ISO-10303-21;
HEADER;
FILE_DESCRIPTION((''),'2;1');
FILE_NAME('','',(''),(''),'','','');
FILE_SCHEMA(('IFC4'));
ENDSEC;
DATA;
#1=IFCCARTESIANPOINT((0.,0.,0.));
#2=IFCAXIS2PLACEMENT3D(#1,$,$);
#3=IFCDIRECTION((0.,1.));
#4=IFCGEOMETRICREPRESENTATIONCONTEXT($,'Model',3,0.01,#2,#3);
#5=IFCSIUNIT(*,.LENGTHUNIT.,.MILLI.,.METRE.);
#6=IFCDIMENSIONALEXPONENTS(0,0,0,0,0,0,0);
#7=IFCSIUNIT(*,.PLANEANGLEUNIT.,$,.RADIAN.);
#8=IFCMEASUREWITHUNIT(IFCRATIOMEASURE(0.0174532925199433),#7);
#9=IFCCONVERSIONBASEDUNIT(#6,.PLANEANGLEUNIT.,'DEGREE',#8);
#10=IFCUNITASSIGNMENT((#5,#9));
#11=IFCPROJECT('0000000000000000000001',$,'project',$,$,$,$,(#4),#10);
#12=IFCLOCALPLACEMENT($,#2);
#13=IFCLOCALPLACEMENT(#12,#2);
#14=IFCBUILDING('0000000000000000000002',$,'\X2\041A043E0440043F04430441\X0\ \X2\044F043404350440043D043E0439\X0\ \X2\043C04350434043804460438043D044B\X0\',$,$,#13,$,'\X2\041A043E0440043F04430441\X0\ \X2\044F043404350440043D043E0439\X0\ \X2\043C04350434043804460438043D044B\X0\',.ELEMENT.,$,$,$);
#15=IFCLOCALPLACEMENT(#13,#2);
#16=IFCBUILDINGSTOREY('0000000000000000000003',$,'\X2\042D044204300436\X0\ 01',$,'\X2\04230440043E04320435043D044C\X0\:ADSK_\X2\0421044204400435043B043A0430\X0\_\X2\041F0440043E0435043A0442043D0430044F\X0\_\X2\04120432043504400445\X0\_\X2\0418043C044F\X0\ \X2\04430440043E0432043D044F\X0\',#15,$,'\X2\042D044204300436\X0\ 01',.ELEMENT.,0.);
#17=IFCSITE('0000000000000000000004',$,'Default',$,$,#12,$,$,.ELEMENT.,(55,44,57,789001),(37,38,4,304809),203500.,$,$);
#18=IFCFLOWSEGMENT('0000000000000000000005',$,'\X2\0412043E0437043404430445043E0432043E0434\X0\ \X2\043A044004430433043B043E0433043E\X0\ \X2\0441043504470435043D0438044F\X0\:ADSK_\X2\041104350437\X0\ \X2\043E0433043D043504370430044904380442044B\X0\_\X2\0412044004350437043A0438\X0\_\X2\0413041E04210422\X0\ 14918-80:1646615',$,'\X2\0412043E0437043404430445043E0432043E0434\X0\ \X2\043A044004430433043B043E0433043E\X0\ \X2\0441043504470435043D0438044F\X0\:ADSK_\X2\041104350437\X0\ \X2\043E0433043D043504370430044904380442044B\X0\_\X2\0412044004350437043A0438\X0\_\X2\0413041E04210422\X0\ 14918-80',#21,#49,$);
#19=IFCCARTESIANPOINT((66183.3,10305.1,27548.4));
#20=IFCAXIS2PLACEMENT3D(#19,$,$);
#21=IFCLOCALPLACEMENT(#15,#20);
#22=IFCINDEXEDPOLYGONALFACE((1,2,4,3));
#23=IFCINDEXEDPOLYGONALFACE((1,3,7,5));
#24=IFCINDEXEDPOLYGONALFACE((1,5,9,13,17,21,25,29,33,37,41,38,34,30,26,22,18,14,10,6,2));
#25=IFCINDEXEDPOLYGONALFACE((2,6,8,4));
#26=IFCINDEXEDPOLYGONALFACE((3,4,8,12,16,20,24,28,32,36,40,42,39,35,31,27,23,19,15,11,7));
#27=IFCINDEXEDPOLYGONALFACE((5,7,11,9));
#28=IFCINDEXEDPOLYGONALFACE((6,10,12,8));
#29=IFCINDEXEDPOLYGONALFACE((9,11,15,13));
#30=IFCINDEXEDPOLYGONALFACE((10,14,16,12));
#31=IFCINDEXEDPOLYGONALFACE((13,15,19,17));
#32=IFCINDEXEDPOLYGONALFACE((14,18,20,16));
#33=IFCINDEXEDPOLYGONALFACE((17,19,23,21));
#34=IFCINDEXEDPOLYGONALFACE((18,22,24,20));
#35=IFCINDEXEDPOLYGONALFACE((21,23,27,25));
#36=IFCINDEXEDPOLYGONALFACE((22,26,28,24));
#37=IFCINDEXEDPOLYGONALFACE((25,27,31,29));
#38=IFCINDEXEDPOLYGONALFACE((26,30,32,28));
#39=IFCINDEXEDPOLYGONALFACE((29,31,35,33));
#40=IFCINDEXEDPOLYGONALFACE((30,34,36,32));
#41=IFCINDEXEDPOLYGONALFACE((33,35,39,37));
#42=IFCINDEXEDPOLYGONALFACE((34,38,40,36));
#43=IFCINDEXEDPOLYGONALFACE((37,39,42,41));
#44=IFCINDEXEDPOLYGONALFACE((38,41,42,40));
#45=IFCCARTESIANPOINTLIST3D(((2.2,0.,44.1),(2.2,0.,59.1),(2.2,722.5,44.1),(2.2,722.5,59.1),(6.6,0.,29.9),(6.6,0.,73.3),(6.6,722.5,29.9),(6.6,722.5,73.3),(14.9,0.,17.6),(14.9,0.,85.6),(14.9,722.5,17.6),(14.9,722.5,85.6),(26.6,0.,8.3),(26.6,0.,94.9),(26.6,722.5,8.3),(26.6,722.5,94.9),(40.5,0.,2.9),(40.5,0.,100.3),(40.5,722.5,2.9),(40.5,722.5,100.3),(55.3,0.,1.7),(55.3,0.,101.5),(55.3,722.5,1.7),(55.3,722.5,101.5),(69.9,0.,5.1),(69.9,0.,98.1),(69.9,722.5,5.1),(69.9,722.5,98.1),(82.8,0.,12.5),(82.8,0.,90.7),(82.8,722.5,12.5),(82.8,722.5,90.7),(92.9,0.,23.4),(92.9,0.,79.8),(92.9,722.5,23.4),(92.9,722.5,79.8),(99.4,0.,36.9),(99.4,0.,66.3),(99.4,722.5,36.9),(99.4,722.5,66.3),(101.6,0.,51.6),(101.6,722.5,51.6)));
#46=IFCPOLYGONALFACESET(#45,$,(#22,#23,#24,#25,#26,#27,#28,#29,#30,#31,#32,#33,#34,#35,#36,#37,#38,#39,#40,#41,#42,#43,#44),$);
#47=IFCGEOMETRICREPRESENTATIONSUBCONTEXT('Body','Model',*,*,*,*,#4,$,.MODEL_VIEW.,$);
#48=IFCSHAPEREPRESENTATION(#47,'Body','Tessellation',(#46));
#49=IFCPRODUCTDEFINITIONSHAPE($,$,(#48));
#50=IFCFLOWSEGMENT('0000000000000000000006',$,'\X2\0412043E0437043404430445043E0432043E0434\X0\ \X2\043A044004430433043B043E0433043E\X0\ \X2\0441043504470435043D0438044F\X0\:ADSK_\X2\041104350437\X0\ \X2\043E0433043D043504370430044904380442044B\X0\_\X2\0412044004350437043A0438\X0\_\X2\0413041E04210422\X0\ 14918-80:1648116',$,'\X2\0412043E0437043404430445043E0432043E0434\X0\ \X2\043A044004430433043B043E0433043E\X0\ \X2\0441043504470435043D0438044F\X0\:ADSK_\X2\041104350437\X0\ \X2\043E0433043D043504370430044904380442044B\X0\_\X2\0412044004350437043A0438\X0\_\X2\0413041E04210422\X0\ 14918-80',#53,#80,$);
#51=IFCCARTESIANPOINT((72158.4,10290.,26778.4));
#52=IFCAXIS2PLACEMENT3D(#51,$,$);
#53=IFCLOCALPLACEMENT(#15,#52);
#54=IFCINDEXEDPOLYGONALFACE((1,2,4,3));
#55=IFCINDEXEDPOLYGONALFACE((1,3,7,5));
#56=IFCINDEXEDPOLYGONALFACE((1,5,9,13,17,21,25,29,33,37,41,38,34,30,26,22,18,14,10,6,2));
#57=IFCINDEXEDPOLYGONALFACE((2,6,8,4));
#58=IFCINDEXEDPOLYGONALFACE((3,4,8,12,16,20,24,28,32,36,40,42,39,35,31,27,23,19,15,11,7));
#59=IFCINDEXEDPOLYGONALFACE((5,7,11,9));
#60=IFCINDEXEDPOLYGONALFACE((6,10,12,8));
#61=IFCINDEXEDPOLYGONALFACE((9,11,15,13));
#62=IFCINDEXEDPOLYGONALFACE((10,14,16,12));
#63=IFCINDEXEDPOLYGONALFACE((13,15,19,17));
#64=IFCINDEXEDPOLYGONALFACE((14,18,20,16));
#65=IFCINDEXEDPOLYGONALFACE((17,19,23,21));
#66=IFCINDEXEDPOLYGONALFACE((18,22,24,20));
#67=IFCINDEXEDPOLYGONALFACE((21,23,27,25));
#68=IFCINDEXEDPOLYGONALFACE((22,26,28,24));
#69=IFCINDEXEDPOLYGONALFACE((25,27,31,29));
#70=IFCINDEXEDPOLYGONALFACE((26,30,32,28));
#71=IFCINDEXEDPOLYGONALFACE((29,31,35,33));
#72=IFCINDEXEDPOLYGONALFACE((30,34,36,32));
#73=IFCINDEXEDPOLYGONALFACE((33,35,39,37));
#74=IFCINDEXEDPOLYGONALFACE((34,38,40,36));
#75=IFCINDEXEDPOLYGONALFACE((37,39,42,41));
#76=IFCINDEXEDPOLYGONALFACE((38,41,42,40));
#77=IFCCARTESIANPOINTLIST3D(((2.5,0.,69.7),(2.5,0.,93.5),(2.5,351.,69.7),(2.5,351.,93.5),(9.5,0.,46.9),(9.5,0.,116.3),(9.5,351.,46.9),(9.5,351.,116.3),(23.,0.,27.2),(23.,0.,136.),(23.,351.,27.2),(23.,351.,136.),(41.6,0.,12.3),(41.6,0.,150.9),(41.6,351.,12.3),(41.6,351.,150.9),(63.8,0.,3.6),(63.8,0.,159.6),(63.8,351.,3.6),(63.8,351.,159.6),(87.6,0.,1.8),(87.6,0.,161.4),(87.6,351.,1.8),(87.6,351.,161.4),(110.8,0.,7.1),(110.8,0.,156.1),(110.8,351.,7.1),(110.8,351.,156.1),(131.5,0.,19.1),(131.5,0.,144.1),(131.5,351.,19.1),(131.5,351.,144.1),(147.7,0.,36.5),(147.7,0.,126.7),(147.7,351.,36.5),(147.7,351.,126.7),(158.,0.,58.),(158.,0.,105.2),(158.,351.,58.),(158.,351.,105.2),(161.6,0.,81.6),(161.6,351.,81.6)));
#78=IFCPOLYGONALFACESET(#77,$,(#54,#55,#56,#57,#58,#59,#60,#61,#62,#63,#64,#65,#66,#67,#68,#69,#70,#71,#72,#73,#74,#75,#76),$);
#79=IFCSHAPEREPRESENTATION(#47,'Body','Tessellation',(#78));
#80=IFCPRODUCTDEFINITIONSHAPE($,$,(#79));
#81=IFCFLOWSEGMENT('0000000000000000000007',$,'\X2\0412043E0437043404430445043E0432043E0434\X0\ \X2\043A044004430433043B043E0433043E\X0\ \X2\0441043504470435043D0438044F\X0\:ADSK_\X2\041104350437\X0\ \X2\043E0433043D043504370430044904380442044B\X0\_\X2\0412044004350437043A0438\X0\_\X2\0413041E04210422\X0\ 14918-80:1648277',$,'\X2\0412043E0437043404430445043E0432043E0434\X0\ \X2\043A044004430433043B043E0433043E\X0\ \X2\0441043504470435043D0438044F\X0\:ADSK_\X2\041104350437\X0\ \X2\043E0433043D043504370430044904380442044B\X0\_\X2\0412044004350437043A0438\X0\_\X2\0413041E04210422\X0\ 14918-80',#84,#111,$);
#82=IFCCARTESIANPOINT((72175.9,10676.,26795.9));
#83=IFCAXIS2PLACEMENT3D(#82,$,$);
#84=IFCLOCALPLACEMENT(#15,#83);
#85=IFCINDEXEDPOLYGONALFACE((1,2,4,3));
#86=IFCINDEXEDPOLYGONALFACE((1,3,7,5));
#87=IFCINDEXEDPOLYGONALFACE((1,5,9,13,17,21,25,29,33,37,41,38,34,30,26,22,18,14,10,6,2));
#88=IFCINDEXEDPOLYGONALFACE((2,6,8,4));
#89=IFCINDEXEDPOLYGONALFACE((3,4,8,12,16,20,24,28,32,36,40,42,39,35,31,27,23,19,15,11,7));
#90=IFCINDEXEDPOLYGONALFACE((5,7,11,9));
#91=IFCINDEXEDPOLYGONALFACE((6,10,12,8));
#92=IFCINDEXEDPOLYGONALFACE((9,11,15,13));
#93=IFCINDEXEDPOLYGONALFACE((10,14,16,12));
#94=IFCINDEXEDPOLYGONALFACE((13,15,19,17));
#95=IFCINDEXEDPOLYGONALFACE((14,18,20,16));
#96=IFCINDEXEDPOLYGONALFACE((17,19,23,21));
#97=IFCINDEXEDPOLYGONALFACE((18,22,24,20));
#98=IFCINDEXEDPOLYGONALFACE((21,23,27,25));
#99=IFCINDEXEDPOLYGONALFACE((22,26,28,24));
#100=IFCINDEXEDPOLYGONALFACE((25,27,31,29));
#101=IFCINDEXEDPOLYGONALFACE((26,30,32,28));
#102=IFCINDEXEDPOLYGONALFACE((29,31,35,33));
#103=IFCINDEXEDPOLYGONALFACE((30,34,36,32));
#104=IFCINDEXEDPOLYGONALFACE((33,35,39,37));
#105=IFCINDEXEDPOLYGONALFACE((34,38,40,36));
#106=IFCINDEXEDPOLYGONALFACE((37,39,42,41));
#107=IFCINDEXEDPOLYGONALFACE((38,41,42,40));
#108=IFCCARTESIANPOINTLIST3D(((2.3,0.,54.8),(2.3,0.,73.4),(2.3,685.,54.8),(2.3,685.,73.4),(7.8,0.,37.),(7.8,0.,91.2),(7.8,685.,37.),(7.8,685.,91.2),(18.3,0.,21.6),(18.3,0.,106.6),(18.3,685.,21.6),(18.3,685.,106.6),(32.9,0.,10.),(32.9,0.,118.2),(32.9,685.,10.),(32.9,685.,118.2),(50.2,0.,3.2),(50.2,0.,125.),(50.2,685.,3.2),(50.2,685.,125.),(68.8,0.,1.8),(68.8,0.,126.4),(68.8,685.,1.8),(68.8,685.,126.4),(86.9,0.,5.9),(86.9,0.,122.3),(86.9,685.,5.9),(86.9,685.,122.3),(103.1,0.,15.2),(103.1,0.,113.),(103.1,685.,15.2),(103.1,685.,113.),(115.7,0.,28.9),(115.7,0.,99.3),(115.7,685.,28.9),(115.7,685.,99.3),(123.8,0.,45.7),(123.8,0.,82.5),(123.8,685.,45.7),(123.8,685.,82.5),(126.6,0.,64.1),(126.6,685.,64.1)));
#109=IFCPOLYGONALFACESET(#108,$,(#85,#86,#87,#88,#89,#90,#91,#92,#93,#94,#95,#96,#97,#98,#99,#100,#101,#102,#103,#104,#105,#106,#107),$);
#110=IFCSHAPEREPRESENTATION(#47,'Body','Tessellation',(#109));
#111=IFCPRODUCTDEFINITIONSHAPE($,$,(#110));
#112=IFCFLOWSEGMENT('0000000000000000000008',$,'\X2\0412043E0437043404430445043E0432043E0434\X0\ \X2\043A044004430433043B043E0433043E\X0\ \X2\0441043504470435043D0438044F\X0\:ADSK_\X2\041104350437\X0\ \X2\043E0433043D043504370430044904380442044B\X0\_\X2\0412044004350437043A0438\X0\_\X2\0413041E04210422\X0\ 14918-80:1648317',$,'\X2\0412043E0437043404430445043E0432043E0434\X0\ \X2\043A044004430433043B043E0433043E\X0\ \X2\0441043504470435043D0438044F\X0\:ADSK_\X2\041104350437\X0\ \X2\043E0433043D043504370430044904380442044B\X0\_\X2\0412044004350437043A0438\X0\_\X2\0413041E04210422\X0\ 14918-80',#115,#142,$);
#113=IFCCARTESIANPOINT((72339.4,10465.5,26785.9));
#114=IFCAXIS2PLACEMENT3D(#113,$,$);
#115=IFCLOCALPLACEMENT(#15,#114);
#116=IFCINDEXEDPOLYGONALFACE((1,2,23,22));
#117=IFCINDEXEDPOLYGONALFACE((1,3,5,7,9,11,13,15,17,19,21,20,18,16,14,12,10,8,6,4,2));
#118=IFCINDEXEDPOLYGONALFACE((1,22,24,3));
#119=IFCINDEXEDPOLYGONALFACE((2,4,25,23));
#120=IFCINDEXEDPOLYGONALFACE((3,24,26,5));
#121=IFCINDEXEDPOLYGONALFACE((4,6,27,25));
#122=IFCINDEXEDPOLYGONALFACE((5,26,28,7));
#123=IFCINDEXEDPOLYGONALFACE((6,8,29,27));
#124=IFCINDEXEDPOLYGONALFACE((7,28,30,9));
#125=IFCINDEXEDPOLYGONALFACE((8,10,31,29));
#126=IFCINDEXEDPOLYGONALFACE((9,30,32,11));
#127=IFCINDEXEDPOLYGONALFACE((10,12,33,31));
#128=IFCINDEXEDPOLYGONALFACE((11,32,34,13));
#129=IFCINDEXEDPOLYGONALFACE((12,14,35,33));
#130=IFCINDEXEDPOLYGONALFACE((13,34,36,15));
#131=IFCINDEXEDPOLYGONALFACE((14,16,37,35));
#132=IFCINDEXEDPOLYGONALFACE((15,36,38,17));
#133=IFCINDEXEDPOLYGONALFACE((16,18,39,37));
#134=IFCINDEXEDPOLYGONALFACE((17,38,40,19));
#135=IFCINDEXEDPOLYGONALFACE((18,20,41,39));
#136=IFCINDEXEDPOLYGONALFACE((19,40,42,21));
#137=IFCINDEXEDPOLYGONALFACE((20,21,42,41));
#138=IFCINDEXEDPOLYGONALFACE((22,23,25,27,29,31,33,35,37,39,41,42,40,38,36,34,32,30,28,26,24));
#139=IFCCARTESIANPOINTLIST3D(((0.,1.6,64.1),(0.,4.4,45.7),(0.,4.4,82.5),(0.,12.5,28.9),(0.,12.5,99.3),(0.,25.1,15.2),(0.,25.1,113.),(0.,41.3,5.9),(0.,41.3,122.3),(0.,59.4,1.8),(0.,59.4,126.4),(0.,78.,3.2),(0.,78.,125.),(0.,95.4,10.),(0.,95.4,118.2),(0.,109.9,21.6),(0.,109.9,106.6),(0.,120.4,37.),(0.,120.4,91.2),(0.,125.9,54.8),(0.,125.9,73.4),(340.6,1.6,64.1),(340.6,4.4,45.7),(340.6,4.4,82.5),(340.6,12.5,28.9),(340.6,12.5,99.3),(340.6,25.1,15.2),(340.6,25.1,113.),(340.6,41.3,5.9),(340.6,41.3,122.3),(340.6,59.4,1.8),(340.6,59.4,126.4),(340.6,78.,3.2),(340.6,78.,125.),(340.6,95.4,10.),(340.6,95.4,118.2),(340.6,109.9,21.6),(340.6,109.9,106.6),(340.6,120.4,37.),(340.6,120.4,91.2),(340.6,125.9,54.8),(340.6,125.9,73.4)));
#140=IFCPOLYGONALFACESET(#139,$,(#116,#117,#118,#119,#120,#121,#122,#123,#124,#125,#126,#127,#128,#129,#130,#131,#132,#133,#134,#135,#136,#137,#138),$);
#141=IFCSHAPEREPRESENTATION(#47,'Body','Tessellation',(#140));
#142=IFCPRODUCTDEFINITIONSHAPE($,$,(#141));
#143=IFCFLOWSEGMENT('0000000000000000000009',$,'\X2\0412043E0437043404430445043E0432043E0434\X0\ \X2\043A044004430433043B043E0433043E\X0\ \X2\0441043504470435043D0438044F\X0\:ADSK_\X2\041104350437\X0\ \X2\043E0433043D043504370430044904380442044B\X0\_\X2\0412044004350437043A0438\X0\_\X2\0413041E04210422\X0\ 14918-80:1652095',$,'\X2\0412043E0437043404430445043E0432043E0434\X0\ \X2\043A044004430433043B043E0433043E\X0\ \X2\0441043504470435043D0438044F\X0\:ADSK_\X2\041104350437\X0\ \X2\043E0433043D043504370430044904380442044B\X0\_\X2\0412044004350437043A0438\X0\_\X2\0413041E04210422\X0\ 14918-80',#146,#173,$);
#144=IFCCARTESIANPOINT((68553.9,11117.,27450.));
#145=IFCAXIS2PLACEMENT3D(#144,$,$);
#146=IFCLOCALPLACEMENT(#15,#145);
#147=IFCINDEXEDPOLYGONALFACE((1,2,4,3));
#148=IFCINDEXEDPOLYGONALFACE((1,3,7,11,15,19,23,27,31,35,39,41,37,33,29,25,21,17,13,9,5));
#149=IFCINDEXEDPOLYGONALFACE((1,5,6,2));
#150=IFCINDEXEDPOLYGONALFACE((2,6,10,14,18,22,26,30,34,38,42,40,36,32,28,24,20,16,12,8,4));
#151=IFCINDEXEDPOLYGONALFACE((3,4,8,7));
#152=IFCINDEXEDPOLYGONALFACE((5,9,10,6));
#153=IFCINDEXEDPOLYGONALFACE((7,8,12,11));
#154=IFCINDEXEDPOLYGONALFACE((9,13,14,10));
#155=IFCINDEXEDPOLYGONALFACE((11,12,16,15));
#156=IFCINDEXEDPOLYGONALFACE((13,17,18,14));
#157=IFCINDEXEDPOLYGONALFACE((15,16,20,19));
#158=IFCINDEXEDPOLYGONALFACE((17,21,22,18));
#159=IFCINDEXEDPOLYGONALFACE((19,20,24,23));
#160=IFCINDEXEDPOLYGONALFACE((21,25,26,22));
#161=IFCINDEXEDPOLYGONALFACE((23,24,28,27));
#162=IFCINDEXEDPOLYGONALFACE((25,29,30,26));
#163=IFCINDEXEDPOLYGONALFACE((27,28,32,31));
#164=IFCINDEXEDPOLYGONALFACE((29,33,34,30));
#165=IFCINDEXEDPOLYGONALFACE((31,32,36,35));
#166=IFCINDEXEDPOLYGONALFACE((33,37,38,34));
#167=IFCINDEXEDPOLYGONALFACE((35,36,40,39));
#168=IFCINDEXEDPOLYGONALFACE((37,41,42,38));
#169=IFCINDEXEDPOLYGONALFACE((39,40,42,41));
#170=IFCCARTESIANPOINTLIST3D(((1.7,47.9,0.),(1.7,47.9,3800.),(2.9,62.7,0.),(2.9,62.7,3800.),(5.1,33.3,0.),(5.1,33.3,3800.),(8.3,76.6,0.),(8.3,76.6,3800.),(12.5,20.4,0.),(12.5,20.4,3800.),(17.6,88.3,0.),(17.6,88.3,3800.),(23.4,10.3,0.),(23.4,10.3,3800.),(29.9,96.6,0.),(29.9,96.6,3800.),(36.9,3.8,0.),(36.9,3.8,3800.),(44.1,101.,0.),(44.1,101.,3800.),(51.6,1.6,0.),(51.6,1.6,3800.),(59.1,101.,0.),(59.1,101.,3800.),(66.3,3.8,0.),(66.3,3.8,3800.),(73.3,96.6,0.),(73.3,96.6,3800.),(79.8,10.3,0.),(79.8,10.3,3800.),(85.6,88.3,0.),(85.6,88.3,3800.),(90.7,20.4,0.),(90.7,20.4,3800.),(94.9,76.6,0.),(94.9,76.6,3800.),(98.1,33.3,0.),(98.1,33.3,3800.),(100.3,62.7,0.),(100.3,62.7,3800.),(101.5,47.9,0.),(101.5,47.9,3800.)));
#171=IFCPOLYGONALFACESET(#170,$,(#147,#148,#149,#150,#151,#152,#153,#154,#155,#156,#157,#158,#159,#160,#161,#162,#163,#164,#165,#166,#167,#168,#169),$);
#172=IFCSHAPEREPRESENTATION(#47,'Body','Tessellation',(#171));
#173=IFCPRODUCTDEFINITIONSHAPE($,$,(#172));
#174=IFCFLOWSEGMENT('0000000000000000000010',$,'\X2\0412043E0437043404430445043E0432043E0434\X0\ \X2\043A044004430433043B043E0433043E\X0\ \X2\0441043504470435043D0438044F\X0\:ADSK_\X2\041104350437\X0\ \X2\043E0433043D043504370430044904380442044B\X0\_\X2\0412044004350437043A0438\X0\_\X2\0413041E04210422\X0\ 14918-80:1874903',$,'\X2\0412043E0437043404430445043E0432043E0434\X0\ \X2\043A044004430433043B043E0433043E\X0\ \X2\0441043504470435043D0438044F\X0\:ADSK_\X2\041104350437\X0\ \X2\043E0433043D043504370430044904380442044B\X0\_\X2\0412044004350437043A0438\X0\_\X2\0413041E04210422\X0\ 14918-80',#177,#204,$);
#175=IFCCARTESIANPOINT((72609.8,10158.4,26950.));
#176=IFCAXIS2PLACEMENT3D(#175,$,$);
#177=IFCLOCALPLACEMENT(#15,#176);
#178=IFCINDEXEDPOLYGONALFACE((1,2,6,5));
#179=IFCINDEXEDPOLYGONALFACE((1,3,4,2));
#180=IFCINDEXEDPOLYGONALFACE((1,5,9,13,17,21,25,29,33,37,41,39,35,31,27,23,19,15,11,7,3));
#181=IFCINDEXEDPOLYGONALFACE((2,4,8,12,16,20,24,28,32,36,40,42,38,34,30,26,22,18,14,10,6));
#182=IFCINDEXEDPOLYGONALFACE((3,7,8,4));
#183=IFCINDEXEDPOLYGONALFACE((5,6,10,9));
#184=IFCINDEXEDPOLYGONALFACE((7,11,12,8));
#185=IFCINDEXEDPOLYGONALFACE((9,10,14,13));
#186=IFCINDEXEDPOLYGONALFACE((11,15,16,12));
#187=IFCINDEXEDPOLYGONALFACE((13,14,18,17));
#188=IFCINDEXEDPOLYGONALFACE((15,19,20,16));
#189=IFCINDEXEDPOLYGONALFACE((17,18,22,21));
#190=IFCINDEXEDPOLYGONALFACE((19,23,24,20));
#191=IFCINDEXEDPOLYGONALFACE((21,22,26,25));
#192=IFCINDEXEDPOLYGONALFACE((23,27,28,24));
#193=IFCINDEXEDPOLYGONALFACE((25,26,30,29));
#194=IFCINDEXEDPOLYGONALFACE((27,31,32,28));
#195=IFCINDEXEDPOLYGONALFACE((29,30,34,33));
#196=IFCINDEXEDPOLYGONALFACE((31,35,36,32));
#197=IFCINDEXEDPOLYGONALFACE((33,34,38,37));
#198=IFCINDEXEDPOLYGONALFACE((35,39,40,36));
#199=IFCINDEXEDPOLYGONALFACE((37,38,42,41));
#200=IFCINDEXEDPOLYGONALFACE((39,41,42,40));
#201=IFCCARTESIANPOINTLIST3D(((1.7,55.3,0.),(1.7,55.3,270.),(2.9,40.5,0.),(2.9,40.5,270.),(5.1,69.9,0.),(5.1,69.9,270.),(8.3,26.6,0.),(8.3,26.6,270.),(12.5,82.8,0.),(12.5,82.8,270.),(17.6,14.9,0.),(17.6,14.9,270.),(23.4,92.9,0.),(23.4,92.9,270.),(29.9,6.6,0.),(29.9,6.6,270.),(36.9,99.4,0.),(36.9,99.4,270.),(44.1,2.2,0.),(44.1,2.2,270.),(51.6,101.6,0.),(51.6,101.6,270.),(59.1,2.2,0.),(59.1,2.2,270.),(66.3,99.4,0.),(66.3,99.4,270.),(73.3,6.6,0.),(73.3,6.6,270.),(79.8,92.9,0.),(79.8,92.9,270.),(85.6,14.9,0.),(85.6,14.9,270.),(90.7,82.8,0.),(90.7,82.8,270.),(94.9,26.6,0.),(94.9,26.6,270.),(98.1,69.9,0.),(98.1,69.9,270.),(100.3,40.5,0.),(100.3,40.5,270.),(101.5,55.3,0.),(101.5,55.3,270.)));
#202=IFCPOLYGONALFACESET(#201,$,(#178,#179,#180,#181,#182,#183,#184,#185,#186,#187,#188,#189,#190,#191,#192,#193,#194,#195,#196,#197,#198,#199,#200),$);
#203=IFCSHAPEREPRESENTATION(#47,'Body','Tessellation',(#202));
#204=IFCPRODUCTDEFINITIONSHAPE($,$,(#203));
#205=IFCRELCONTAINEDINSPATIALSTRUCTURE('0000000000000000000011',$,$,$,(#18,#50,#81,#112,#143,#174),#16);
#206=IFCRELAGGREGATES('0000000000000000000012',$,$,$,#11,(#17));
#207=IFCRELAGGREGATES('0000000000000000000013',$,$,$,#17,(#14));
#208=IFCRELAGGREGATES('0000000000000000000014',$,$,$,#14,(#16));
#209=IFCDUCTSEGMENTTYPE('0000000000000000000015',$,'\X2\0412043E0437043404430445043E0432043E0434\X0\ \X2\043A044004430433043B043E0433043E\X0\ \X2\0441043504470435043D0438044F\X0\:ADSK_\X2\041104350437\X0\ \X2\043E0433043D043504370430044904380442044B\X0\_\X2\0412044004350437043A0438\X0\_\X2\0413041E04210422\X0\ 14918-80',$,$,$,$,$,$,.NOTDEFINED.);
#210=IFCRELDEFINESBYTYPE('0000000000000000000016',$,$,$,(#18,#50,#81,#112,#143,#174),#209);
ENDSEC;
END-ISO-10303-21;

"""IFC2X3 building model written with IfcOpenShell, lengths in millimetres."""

from ifc_helpers import new_model, entity, si_unit, converted_unit, direction, frame, origin, origin_2d_with_axis, place, context, subcontext, project, spatial, circle, extrude, type_object, element, save


model = new_model("IFC2X3")

# Units and contexts
model_context = context("Model", 3, precision=0.01, world=origin(), true_north=direction((0.0, 1.0)))
body_context = subcontext(model_context, "Body", "Model", "MODEL_VIEW")
ifc_project = project(units=[si_unit("LENGTHUNIT", "METRE", prefix="MILLI"), converted_unit("PLANEANGLEUNIT", "DEGREE", entity("IfcRatioMeasure", 0.0174532925199433), si_unit("PLANEANGLEUNIT", "RADIAN"), dimensions=[0, 0, 0, 0, 0, 0, 0])], contexts=[model_context])

# Site, building, storey
site_placement = place(None, origin())
site = spatial("IfcSite", under=ifc_project, at=site_placement, Name="Default", CompositionType="ELEMENT", RefLatitude=(55, 44, 57, 789001), RefLongitude=(37, 38, 4, 304809), RefElevation=203500.0)
building_placement = place(site_placement, origin())
building = spatial("IfcBuilding", under=site, at=building_placement, Name="Корпус ядерной медицины", LongName="Корпус ядерной медицины", CompositionType="ELEMENT")
storey_placement = place(building_placement, origin())
storey = spatial("IfcBuildingStorey", under=building, at=storey_placement, Name="Этаж 01", ObjectType="Уровень:ADSK_Стрелка_Проектная_Вверх_Имя уровня", LongName="Этаж 01", CompositionType="ELEMENT", Elevation=0.0)

# Flow segments
duct_segment_type_1 = type_object("IfcDuctSegmentType", Name="Воздуховод круглого сечения:ADSK_Без огнезащиты_Врезки_ГОСТ 14918-80", PredefinedType="NOTDEFINED")
flow_segment_1_placement = place(storey_placement, frame((66183.3, 10305.1, 27548.4)))
element("IfcFlowSegment", 1, at=flow_segment_1_placement, inside=storey, type_object=duct_segment_type_1, Name="Воздуховод круглого сечения:ADSK_Без огнезащиты_Врезки_ГОСТ 14918-80:1646615", ObjectType="Воздуховод круглого сечения:ADSK_Без огнезащиты_Врезки_ГОСТ 14918-80", context=body_context, shape_type="SweptSolid", body=[
    extrude(circle(Radius=50.0, at=origin_2d_with_axis()), frame((51.6, 0.0, 51.6), z_axis=(0.0, 1.0, 0.0), x_axis=(1.0, 0.0, 0.0)), (0.0, 0.0, 1.0), 722.5),
])
flow_segment_2_placement = place(storey_placement, frame((72158.4, 10290.0, 26778.4)))
element("IfcFlowSegment", 2, at=flow_segment_2_placement, inside=storey, type_object=duct_segment_type_1, Name="Воздуховод круглого сечения:ADSK_Без огнезащиты_Врезки_ГОСТ 14918-80:1648116", ObjectType="Воздуховод круглого сечения:ADSK_Без огнезащиты_Врезки_ГОСТ 14918-80", context=body_context, shape_type="SweptSolid", body=[
    extrude(circle(Radius=80.0, at=origin_2d_with_axis()), frame((81.6, 0.0, 81.6), z_axis=(0.0, 1.0, 0.0), x_axis=(1.0, 0.0, 0.0)), (0.0, 0.0, 1.0), 351.0),
])
flow_segment_3_placement = place(storey_placement, frame((72175.9, 10676.0, 26795.9)))
element("IfcFlowSegment", 3, at=flow_segment_3_placement, inside=storey, type_object=duct_segment_type_1, Name="Воздуховод круглого сечения:ADSK_Без огнезащиты_Врезки_ГОСТ 14918-80:1648277", ObjectType="Воздуховод круглого сечения:ADSK_Без огнезащиты_Врезки_ГОСТ 14918-80", context=body_context, shape_type="SweptSolid", body=[
    extrude(circle(Radius=62.5, at=origin_2d_with_axis()), frame((64.1, 0.0, 64.1), z_axis=(0.0, 1.0, 0.0), x_axis=(1.0, 0.0, 0.0)), (0.0, 0.0, 1.0), 685.0),
])
flow_segment_4_placement = place(storey_placement, frame((72339.4, 10465.5, 26785.9)))
element("IfcFlowSegment", 4, at=flow_segment_4_placement, inside=storey, type_object=duct_segment_type_1, Name="Воздуховод круглого сечения:ADSK_Без огнезащиты_Врезки_ГОСТ 14918-80:1648317", ObjectType="Воздуховод круглого сечения:ADSK_Без огнезащиты_Врезки_ГОСТ 14918-80", context=body_context, shape_type="SweptSolid", body=[
    extrude(circle(Radius=62.5, at=origin_2d_with_axis()), frame((0.0, 64.1, 64.1), z_axis=(1.0, 0.0, 0.0), x_axis=(0.0, -1.0, 0.0)), (0.0, 0.0, 1.0), 340.6),
])
flow_segment_5_placement = place(storey_placement, frame((68553.9, 11117.0, 27450.0)))
element("IfcFlowSegment", 5, at=flow_segment_5_placement, inside=storey, type_object=duct_segment_type_1, Name="Воздуховод круглого сечения:ADSK_Без огнезащиты_Врезки_ГОСТ 14918-80:1652095", ObjectType="Воздуховод круглого сечения:ADSK_Без огнезащиты_Врезки_ГОСТ 14918-80", context=body_context, shape_type="SweptSolid", body=[
    extrude(circle(Radius=50.0, at=origin_2d_with_axis()), frame((51.6, 51.6, 0.0), z_axis=(0.0, 0.0, 1.0), x_axis=(0.0, -1.0, 0.0)), (0.0, 0.0, 1.0), 3800.0),
])
flow_segment_6_placement = place(storey_placement, frame((72609.8, 10158.4, 26950.0)))
element("IfcFlowSegment", 6, at=flow_segment_6_placement, inside=storey, type_object=duct_segment_type_1, Name="Воздуховод круглого сечения:ADSK_Без огнезащиты_Врезки_ГОСТ 14918-80:1874903", ObjectType="Воздуховод круглого сечения:ADSK_Без огнезащиты_Врезки_ГОСТ 14918-80", context=body_context, shape_type="SweptSolid", body=[
    extrude(circle(Radius=50.0, at=origin_2d_with_axis()), frame((51.6, 51.6, 0.0), z_axis=(0.0, 0.0, 1.0), x_axis=(0.0, 1.0, 0.0)), (0.0, 0.0, 1.0), 270.0),
])

save(model, "model.ifc")
